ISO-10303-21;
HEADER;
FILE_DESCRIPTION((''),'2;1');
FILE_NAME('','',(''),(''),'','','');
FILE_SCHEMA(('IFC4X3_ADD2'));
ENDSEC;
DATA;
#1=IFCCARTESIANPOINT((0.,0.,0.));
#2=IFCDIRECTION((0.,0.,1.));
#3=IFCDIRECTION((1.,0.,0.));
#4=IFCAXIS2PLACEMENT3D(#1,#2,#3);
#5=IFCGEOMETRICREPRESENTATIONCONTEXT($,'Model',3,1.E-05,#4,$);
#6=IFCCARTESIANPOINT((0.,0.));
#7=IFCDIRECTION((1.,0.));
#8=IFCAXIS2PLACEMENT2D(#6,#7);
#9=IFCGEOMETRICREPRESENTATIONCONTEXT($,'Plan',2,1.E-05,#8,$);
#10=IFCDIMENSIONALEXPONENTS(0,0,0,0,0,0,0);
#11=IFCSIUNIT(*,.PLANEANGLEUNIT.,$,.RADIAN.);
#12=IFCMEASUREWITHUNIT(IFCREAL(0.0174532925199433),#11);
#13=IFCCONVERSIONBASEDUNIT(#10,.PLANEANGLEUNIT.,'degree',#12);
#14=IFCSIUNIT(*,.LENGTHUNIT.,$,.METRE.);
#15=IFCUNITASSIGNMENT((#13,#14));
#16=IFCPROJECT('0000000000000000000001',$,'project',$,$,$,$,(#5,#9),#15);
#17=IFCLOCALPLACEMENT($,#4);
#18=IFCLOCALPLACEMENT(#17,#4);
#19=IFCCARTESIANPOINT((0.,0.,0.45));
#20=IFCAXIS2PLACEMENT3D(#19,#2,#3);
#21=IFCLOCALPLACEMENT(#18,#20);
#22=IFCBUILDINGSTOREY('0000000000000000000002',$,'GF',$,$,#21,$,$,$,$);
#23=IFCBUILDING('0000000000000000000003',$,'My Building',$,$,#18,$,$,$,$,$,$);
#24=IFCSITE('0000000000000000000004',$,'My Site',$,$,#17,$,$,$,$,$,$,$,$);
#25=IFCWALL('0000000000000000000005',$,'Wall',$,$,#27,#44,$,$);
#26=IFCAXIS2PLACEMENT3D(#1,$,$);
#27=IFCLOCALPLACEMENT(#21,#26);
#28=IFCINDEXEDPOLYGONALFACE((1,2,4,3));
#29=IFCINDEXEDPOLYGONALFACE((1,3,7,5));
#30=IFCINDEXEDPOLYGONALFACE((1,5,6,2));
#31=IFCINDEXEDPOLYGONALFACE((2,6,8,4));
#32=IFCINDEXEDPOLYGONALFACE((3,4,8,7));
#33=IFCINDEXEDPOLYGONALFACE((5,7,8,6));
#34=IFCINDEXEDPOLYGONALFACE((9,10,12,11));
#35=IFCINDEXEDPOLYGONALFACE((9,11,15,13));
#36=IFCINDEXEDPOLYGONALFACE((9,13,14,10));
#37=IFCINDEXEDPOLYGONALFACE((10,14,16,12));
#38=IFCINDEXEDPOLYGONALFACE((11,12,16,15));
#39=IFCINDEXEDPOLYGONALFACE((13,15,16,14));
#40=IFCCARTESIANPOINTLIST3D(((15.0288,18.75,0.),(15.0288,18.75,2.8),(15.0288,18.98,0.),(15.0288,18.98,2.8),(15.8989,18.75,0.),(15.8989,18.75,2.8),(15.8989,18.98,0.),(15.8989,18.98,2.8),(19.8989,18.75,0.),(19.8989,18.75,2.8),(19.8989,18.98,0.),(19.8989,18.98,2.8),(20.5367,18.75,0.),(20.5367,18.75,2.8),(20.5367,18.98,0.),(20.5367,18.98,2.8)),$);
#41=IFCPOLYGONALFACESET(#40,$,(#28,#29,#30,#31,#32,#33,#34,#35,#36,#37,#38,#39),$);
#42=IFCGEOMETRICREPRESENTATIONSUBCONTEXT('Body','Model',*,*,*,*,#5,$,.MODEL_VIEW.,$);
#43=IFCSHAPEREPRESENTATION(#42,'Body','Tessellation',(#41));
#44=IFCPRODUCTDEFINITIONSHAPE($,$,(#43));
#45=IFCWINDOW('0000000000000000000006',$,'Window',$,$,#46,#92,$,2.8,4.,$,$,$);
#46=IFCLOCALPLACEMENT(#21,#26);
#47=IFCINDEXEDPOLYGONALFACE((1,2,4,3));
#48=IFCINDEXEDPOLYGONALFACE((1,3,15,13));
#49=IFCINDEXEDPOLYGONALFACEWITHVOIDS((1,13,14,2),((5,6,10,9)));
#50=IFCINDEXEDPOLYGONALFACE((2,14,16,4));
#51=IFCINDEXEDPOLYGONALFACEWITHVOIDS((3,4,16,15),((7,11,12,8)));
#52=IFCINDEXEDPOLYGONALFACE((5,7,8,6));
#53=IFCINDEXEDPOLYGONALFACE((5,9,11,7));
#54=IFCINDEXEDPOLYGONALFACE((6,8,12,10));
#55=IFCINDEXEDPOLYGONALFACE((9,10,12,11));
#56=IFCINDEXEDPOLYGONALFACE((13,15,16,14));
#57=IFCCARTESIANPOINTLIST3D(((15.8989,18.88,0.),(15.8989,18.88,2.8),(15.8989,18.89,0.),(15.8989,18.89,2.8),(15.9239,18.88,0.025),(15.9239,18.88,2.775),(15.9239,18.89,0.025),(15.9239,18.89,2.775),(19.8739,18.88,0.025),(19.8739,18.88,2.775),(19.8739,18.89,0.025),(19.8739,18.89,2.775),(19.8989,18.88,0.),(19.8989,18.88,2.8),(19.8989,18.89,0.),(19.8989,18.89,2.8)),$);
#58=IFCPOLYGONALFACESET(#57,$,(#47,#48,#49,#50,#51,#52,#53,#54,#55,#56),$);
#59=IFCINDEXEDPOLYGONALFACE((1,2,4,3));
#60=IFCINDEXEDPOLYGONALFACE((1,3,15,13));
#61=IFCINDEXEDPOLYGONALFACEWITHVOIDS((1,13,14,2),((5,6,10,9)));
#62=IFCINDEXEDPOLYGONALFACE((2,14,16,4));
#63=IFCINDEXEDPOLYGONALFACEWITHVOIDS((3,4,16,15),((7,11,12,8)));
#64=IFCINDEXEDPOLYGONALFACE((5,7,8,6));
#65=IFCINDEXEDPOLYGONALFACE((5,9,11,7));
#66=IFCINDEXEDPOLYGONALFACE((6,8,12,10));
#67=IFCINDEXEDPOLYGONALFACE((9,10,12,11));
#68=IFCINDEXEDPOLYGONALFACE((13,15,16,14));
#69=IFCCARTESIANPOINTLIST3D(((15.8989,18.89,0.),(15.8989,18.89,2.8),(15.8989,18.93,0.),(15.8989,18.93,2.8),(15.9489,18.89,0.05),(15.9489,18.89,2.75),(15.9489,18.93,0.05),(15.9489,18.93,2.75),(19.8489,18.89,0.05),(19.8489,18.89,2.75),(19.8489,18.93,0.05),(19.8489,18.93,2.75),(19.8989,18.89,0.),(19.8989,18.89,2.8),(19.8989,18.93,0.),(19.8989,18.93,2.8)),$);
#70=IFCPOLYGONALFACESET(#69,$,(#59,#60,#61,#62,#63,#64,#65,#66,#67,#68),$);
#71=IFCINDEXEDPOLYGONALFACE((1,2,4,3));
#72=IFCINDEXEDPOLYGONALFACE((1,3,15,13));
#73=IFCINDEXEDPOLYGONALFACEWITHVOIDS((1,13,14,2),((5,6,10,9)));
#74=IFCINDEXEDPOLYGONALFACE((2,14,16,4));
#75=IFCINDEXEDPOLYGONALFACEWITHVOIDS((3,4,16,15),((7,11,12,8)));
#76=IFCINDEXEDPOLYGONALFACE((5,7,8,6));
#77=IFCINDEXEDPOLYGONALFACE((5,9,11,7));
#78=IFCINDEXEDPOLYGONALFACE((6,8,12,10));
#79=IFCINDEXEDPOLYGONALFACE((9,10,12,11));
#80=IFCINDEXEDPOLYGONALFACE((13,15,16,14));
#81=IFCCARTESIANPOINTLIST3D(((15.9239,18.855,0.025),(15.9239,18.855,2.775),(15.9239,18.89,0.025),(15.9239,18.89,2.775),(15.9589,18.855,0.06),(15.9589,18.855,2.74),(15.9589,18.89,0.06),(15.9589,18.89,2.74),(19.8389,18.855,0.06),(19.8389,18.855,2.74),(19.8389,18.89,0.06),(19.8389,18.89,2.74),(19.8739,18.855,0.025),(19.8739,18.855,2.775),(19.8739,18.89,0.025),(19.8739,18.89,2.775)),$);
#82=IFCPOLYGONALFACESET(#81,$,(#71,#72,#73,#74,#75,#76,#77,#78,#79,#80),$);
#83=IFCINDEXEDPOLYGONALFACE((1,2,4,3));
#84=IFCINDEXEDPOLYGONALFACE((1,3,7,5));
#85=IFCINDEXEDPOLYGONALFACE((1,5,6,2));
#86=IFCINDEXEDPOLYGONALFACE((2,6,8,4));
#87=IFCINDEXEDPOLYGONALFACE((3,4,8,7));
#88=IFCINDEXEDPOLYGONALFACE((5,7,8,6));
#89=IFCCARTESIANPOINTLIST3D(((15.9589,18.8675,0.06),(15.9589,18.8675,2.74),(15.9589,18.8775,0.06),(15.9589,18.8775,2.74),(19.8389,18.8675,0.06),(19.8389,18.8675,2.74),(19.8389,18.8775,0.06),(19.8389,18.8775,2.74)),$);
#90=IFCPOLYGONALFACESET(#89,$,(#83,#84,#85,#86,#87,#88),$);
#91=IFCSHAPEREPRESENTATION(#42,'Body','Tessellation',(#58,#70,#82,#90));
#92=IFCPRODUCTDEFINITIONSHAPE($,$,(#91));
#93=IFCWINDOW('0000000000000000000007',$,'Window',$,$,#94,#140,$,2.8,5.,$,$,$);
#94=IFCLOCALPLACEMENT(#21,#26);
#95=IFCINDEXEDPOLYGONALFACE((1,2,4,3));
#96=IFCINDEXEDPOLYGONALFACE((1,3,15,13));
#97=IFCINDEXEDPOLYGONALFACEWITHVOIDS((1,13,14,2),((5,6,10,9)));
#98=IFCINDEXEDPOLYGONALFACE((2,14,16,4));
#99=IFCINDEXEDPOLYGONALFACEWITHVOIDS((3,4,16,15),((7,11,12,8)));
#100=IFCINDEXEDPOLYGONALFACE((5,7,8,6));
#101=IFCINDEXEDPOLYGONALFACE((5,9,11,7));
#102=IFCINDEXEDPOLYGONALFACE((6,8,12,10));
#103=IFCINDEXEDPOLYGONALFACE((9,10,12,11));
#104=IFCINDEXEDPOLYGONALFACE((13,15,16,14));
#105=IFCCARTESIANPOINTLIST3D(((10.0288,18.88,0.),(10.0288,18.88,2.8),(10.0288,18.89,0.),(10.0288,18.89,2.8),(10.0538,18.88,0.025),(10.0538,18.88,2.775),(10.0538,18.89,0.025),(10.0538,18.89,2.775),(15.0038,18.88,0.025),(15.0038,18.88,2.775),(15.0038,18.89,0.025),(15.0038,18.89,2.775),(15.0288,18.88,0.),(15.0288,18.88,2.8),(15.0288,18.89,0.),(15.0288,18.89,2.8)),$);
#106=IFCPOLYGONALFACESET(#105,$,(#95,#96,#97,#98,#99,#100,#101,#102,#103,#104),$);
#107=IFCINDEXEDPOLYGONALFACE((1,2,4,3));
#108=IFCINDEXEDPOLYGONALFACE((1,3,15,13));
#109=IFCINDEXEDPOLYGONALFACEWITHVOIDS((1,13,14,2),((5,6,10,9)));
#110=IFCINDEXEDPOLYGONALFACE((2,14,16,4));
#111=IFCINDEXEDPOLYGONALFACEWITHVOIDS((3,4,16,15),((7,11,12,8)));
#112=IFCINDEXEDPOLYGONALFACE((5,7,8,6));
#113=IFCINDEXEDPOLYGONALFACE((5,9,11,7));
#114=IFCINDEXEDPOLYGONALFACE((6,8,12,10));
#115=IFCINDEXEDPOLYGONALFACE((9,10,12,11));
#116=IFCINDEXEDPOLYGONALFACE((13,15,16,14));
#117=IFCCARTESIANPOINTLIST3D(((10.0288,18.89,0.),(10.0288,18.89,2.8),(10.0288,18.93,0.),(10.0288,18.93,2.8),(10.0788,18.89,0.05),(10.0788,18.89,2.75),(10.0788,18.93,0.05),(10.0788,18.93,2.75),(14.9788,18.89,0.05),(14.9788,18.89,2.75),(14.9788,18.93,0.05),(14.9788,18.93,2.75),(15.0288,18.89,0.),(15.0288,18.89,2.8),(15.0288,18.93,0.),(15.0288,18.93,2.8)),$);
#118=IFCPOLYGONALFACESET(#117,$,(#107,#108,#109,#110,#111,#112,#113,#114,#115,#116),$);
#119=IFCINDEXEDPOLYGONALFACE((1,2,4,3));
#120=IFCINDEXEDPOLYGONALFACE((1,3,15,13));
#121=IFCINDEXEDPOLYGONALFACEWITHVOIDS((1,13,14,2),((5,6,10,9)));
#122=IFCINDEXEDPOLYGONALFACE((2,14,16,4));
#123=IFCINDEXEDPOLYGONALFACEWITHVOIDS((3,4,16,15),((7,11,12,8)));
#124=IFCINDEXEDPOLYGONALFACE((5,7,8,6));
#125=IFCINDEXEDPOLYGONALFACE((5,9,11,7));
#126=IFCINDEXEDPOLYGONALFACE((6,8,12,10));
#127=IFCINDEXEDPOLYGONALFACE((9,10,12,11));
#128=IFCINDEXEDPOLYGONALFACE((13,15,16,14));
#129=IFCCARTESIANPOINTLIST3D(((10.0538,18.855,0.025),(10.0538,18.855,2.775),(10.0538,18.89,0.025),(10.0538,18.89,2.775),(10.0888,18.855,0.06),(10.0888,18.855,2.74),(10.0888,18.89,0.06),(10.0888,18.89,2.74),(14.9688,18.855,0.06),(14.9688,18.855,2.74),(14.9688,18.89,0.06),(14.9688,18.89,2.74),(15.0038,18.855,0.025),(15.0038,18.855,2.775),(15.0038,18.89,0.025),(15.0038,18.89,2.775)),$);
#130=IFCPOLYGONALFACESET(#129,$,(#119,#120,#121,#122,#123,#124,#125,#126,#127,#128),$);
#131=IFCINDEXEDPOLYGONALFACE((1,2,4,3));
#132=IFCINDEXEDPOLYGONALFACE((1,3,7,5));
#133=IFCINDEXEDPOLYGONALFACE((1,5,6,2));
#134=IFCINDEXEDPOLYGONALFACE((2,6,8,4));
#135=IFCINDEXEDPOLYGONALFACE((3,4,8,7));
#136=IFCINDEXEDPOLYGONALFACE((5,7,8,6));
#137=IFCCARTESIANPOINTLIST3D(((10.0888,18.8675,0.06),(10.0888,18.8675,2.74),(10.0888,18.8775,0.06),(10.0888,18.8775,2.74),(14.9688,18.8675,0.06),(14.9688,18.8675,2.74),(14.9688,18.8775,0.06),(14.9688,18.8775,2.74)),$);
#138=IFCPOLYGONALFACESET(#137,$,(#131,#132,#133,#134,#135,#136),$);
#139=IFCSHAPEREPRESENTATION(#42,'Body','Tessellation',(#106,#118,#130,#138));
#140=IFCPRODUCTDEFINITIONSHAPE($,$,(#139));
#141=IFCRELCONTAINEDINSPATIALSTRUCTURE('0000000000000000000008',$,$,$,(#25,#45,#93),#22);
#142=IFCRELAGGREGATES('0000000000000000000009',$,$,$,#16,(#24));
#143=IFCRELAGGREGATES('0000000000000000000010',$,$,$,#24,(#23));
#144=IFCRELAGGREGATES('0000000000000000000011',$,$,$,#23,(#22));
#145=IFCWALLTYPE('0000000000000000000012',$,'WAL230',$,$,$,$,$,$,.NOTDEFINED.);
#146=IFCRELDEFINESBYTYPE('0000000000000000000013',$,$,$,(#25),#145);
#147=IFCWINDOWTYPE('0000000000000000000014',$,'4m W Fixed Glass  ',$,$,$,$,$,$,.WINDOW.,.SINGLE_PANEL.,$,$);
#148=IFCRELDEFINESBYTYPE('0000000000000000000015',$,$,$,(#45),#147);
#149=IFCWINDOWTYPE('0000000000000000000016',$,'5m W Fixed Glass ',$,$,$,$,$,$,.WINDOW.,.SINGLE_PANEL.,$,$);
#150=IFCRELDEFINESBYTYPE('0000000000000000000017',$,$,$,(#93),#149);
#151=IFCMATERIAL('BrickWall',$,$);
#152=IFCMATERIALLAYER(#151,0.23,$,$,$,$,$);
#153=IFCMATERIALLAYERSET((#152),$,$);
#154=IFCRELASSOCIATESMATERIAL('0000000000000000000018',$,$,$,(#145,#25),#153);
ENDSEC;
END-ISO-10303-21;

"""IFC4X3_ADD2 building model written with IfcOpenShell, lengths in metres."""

from ifc_helpers import new_model, entity, si_unit, converted_unit, frame, origin_with_axes, origin_2d_with_axis, place, context, subcontext, project, spatial, line, indexed_curve, outline, extrude, shape, source, transform, mapped, material, layer, layer_set, layer_usage, type_object, type_shapes, element, fill, save


model = new_model("IFC4X3_ADD2")

# Units and contexts
model_context = context("Model", 3, precision=1e-05, world=origin_with_axes())
plan_context = context("Plan", 2, precision=1e-05, world=origin_2d_with_axis())
body_context_1 = subcontext(model_context, "Body", "Model", "MODEL_VIEW")
body_context_2 = subcontext(plan_context, "Body", "Plan", "PLAN_VIEW")
ifc_project = project(units=[converted_unit("PLANEANGLEUNIT", "degree", entity("IfcReal", 0.0174532925199433), si_unit("PLANEANGLEUNIT", "RADIAN"), dimensions=[0, 0, 0, 0, 0, 0, 0]), si_unit("LENGTHUNIT", "METRE")], contexts=[model_context, plan_context])

# Site, building, storey
site_placement = place(None, origin_with_axes())
site = spatial("IfcSite", under=ifc_project, at=site_placement, Name="My Site")
building_placement = place(site_placement, origin_with_axes())
building = spatial("IfcBuilding", under=site, at=building_placement, Name="My Building")
storey_placement = place(building_placement, frame((0.0, 0.0, 0.45), z_axis=(0.0, 0.0, 1.0), x_axis=(1.0, 0.0, 0.0)))
storey = spatial("IfcBuildingStorey", under=building, at=storey_placement, Name="GF")

# Wall, openings, windows
ifc_material_1 = material(Name="BrickWall")
ifc_layer_1 = layer(ifc_material_1, 0.23)
ifc_layer_set_1 = layer_set([ifc_layer_1])
ifc_layer_usage_1 = layer_usage(ifc_layer_set_1, "AXIS2", "POSITIVE", 0.0)
wall_type_1 = type_object("IfcWallType", Name="WAL230", PredefinedType="NOTDEFINED", material=ifc_layer_set_1)
wall_1_placement = place(storey_placement, frame((20.5367, 18.98, 0.0), z_axis=(0.0, 0.0, 1.0), x_axis=(-1.0, 0.0, 0.0)))
wall_1 = element("IfcWall", 1, at=wall_1_placement, inside=storey, type_object=wall_type_1, material=ifc_layer_usage_1, Name="Wall", context=body_context_1, shape_type="SweptSolid", body=[
    extrude(outline(indexed_curve([(0.0, 0.0), (0.0, 0.23), (10.5079, 0.23), (10.5079, 0.0), (0.0, 0.0)], self_intersect=False)), origin_with_axes(), (0.0, 0.0, 1.0), 2.8),
])
shared_shape_1 = source(origin_with_axes(), body_context_1, "Body", "SweptSolid", [
    extrude(outline(indexed_curve([(0.0, 0.0), (5.0, 0.0), (5.0, 2.8), (0.0, 2.8)], segments=[line(1, 2, 3, 4, 1)])), frame((0.0, -0.6, 0.0), z_axis=(0.0, -1.0, 0.0), x_axis=(1.0, 0.0, 0.0)), (0.0, 0.0, -1.0), 1.2),
])
opening_1_placement = place(wall_1_placement, frame((5.5079, 0.0, 0.0), z_axis=(0.0, 0.0, 1.0), x_axis=(1.0, 0.0, 0.0)))
opening_1 = element("IfcOpeningElement", 2, at=opening_1_placement, cuts=wall_1, PredefinedType="OPENING", context=body_context_1, shape_type="MappedRepresentation", body=[
    mapped(shared_shape_1, transform((0.0, 0.0, 0.0), x_axis=(1.0, 0.0, 0.0), y_axis=(0.0, 1.0, 0.0), z_axis=(0.0, 0.0, 1.0), scale=1.0)),
])
shared_shape_2 = source(origin_with_axes(), body_context_1, "Body", "SweptSolid", [
    extrude(outline(indexed_curve([(0.0, 0.0), (4.0, 0.0), (4.0, 2.8), (0.0, 2.8)], segments=[line(1, 2, 3, 4, 1)])), frame((0.0, -0.6, 0.0), z_axis=(0.0, -1.0, 0.0), x_axis=(1.0, 0.0, 0.0)), (0.0, 0.0, -1.0), 1.2),
])
opening_2_placement = place(wall_1_placement, frame((0.6379, 0.0, 0.0), z_axis=(0.0, 0.0, 1.0), x_axis=(1.0, 0.0, 0.0)))
opening_2 = element("IfcOpeningElement", 3, at=opening_2_placement, cuts=wall_1, PredefinedType="OPENING", context=body_context_1, shape_type="MappedRepresentation", body=[
    mapped(shared_shape_2, transform((0.0, 0.0, 0.0), x_axis=(1.0, 0.0, 0.0), y_axis=(0.0, 1.0, 0.0), z_axis=(0.0, 0.0, 1.0), scale=1.0)),
])
window_type_1 = type_object("IfcWindowType", Name="4m W Fixed Glass  ", PartitioningType="SINGLE_PANEL", PredefinedType="WINDOW")
shared_shape_3 = source(origin_with_axes(), body_context_1, "Body", "SweptSolid", [
    extrude(outline(indexed_curve([(0.0, 0.0), (4.0, 0.0), (4.0, 2.8), (0.0, 2.8)], segments=[line(1, 2, 3, 4, 1)]), holes=[indexed_curve([(0.025, 0.025), (3.975, 0.025), (3.975, 2.775), (0.025, 2.775)], segments=[line(1, 2, 3, 4, 1)])]), frame((0.0, 0.09, 0.0), z_axis=(0.0, -1.0, 0.0), x_axis=(1.0, 0.0, 0.0)), (0.0, 0.0, -1.0), 0.01),
    extrude(outline(indexed_curve([(0.0, 0.0), (4.0, 0.0), (4.0, 2.8), (0.0, 2.8)], segments=[line(1, 2, 3, 4, 1)]), holes=[indexed_curve([(0.05, 0.05), (3.95, 0.05), (3.95, 2.75), (0.05, 2.75)], segments=[line(1, 2, 3, 4, 1)])]), frame((0.0, 0.05, 0.0), z_axis=(0.0, -1.0, 0.0), x_axis=(1.0, 0.0, 0.0)), (0.0, 0.0, -1.0), 0.04),
    extrude(outline(indexed_curve([(0.0, 0.0), (3.95, 0.0), (3.95, 2.75), (0.0, 2.75)], segments=[line(1, 2, 3, 4, 1)]), holes=[indexed_curve([(0.035, 0.035), (3.915, 0.035), (3.915, 2.715), (0.035, 2.715)], segments=[line(1, 2, 3, 4, 1)])]), frame((0.025, 0.09, 0.025), z_axis=(0.0, -1.0, 0.0), x_axis=(1.0, 0.0, 0.0)), (0.0, 0.0, -1.0), 0.035),
    extrude(outline(indexed_curve([(0.035, 0.035), (3.915, 0.035), (3.915, 2.715), (0.035, 2.715)], segments=[line(1, 2, 3, 4, 1)])), frame((0.025, 0.1025, 0.025), z_axis=(0.0, -1.0, 0.0), x_axis=(1.0, 0.0, 0.0)), (0.0, 0.0, -1.0), 0.01),
])
shared_shape_4 = source(origin_with_axes(), body_context_2, "Body", "Curve2D", [
    entity("IfcIndexedPolyCurve", entity("IfcCartesianPointList2D", [[0.05, 0.05], [3.95, 0.05]])),
    entity("IfcIndexedPolyCurve", entity("IfcCartesianPointList2D", [[0.0, 0.1], [0.025, 0.1], [0.025, 0.09], [0.05, 0.09], [0.05, 0.05], [0.0, 0.05]]), [entity("IfcLineIndex", [1, 2, 3, 4, 5, 6, 1])]),
    entity("IfcIndexedPolyCurve", entity("IfcCartesianPointList2D", [[4.0, 0.1], [3.975, 0.1], [3.975, 0.09], [3.95, 0.09], [3.95, 0.05], [4.0, 0.05]]), [entity("IfcLineIndex", [1, 2, 3, 4, 5, 6, 1])]),
    entity("IfcIndexedPolyCurve", entity("IfcCartesianPointList2D", [[0.025, 0.09], [0.06, 0.09], [0.06, 0.125], [0.025, 0.125]]), [entity("IfcLineIndex", [1, 2, 3, 4, 1])]),
    entity("IfcIndexedPolyCurve", entity("IfcCartesianPointList2D", [[3.975, 0.09], [3.94, 0.09], [3.94, 0.125], [3.975, 0.125]]), [entity("IfcLineIndex", [1, 2, 3, 4, 1])]),
    entity("IfcIndexedPolyCurve", entity("IfcCartesianPointList2D", [[0.06, 0.09], [3.94, 0.09]])),
    entity("IfcIndexedPolyCurve", entity("IfcCartesianPointList2D", [[0.06, 0.125], [3.94, 0.125]])),
    entity("IfcIndexedPolyCurve", entity("IfcCartesianPointList2D", [[0.06, 0.1075], [3.94, 0.1075]])),
])
type_shapes(window_type_1, [shared_shape_3, shared_shape_4])
window_1_placement = place(opening_2_placement, frame((0.0, 0.0, 0.0), z_axis=(0.0, 0.0, 1.0), x_axis=(1.0, 0.0, 0.0)))
window_1 = element("IfcWindow", 4, at=window_1_placement, inside=storey, type_object=window_type_1, Name="Window", OverallHeight=2.8, OverallWidth=4.0, shapes=[
    shape(body_context_1, "Body", "MappedRepresentation", [mapped(shared_shape_3, transform((0.0, 0.0, 0.0), x_axis=(1.0, 0.0, 0.0), y_axis=(0.0, 1.0, 0.0), z_axis=(0.0, 0.0, 1.0), scale=1.0))]),
    shape(body_context_2, "Body", "MappedRepresentation", [mapped(shared_shape_4, transform((0.0, 0.0, 0.0), x_axis=(1.0, 0.0, 0.0), y_axis=(0.0, 1.0, 0.0), z_axis=(0.0, 0.0, 1.0), scale=1.0))]),
])
fill(opening_2, window_1)
window_type_2 = type_object("IfcWindowType", Name="5m W Fixed Glass ", PartitioningType="SINGLE_PANEL", PredefinedType="WINDOW")
shared_shape_5 = source(origin_with_axes(), body_context_1, "Body", "SweptSolid", [
    extrude(outline(indexed_curve([(0.0, 0.0), (5.0, 0.0), (5.0, 2.8), (0.0, 2.8)], segments=[line(1, 2, 3, 4, 1)]), holes=[indexed_curve([(0.025, 0.025), (4.975, 0.025), (4.975, 2.775), (0.025, 2.775)], segments=[line(1, 2, 3, 4, 1)])]), frame((0.0, 0.09, 0.0), z_axis=(0.0, -1.0, 0.0), x_axis=(1.0, 0.0, 0.0)), (0.0, 0.0, -1.0), 0.01),
    extrude(outline(indexed_curve([(0.0, 0.0), (5.0, 0.0), (5.0, 2.8), (0.0, 2.8)], segments=[line(1, 2, 3, 4, 1)]), holes=[indexed_curve([(0.05, 0.05), (4.95, 0.05), (4.95, 2.75), (0.05, 2.75)], segments=[line(1, 2, 3, 4, 1)])]), frame((0.0, 0.05, 0.0), z_axis=(0.0, -1.0, 0.0), x_axis=(1.0, 0.0, 0.0)), (0.0, 0.0, -1.0), 0.04),
    extrude(outline(indexed_curve([(0.0, 0.0), (4.95, 0.0), (4.95, 2.75), (0.0, 2.75)], segments=[line(1, 2, 3, 4, 1)]), holes=[indexed_curve([(0.035, 0.035), (4.915, 0.035), (4.915, 2.715), (0.035, 2.715)], segments=[line(1, 2, 3, 4, 1)])]), frame((0.025, 0.09, 0.025), z_axis=(0.0, -1.0, 0.0), x_axis=(1.0, 0.0, 0.0)), (0.0, 0.0, -1.0), 0.035),
    extrude(outline(indexed_curve([(0.035, 0.035), (4.915, 0.035), (4.915, 2.715), (0.035, 2.715)], segments=[line(1, 2, 3, 4, 1)])), frame((0.025, 0.1025, 0.025), z_axis=(0.0, -1.0, 0.0), x_axis=(1.0, 0.0, 0.0)), (0.0, 0.0, -1.0), 0.01),
])
shared_shape_6 = source(origin_with_axes(), body_context_2, "Body", "Curve2D", [
    entity("IfcIndexedPolyCurve", entity("IfcCartesianPointList2D", [[0.05, 0.05], [4.95, 0.05]])),
    entity("IfcIndexedPolyCurve", entity("IfcCartesianPointList2D", [[0.0, 0.1], [0.025, 0.1], [0.025, 0.09], [0.05, 0.09], [0.05, 0.05], [0.0, 0.05]]), [entity("IfcLineIndex", [1, 2, 3, 4, 5, 6, 1])]),
    entity("IfcIndexedPolyCurve", entity("IfcCartesianPointList2D", [[5.0, 0.1], [4.975, 0.1], [4.975, 0.09], [4.95, 0.09], [4.95, 0.05], [5.0, 0.05]]), [entity("IfcLineIndex", [1, 2, 3, 4, 5, 6, 1])]),
    entity("IfcIndexedPolyCurve", entity("IfcCartesianPointList2D", [[0.025, 0.09], [0.06, 0.09], [0.06, 0.125], [0.025, 0.125]]), [entity("IfcLineIndex", [1, 2, 3, 4, 1])]),
    entity("IfcIndexedPolyCurve", entity("IfcCartesianPointList2D", [[4.975, 0.09], [4.94, 0.09], [4.94, 0.125], [4.975, 0.125]]), [entity("IfcLineIndex", [1, 2, 3, 4, 1])]),
    entity("IfcIndexedPolyCurve", entity("IfcCartesianPointList2D", [[0.06, 0.09], [4.94, 0.09]])),
    entity("IfcIndexedPolyCurve", entity("IfcCartesianPointList2D", [[0.06, 0.125], [4.94, 0.125]])),
    entity("IfcIndexedPolyCurve", entity("IfcCartesianPointList2D", [[0.06, 0.1075], [4.94, 0.1075]])),
])
type_shapes(window_type_2, [shared_shape_5, shared_shape_6])
window_2_placement = place(opening_1_placement, frame((0.0, 0.0, 0.0), z_axis=(0.0, 0.0, 1.0), x_axis=(1.0, 0.0, 0.0)))
window_2 = element("IfcWindow", 5, at=window_2_placement, inside=storey, type_object=window_type_2, Name="Window", OverallHeight=2.8, OverallWidth=5.0, shapes=[
    shape(body_context_1, "Body", "MappedRepresentation", [mapped(shared_shape_5, transform((0.0, 0.0, 0.0), x_axis=(1.0, 0.0, 0.0), y_axis=(0.0, 1.0, 0.0), z_axis=(0.0, 0.0, 1.0), scale=1.0))]),
    shape(body_context_2, "Body", "MappedRepresentation", [mapped(shared_shape_6, transform((0.0, 0.0, 0.0), x_axis=(1.0, 0.0, 0.0), y_axis=(0.0, 1.0, 0.0), z_axis=(0.0, 0.0, 1.0), scale=1.0))]),
])
fill(opening_1, window_2)

save(model, "model.ifc")
